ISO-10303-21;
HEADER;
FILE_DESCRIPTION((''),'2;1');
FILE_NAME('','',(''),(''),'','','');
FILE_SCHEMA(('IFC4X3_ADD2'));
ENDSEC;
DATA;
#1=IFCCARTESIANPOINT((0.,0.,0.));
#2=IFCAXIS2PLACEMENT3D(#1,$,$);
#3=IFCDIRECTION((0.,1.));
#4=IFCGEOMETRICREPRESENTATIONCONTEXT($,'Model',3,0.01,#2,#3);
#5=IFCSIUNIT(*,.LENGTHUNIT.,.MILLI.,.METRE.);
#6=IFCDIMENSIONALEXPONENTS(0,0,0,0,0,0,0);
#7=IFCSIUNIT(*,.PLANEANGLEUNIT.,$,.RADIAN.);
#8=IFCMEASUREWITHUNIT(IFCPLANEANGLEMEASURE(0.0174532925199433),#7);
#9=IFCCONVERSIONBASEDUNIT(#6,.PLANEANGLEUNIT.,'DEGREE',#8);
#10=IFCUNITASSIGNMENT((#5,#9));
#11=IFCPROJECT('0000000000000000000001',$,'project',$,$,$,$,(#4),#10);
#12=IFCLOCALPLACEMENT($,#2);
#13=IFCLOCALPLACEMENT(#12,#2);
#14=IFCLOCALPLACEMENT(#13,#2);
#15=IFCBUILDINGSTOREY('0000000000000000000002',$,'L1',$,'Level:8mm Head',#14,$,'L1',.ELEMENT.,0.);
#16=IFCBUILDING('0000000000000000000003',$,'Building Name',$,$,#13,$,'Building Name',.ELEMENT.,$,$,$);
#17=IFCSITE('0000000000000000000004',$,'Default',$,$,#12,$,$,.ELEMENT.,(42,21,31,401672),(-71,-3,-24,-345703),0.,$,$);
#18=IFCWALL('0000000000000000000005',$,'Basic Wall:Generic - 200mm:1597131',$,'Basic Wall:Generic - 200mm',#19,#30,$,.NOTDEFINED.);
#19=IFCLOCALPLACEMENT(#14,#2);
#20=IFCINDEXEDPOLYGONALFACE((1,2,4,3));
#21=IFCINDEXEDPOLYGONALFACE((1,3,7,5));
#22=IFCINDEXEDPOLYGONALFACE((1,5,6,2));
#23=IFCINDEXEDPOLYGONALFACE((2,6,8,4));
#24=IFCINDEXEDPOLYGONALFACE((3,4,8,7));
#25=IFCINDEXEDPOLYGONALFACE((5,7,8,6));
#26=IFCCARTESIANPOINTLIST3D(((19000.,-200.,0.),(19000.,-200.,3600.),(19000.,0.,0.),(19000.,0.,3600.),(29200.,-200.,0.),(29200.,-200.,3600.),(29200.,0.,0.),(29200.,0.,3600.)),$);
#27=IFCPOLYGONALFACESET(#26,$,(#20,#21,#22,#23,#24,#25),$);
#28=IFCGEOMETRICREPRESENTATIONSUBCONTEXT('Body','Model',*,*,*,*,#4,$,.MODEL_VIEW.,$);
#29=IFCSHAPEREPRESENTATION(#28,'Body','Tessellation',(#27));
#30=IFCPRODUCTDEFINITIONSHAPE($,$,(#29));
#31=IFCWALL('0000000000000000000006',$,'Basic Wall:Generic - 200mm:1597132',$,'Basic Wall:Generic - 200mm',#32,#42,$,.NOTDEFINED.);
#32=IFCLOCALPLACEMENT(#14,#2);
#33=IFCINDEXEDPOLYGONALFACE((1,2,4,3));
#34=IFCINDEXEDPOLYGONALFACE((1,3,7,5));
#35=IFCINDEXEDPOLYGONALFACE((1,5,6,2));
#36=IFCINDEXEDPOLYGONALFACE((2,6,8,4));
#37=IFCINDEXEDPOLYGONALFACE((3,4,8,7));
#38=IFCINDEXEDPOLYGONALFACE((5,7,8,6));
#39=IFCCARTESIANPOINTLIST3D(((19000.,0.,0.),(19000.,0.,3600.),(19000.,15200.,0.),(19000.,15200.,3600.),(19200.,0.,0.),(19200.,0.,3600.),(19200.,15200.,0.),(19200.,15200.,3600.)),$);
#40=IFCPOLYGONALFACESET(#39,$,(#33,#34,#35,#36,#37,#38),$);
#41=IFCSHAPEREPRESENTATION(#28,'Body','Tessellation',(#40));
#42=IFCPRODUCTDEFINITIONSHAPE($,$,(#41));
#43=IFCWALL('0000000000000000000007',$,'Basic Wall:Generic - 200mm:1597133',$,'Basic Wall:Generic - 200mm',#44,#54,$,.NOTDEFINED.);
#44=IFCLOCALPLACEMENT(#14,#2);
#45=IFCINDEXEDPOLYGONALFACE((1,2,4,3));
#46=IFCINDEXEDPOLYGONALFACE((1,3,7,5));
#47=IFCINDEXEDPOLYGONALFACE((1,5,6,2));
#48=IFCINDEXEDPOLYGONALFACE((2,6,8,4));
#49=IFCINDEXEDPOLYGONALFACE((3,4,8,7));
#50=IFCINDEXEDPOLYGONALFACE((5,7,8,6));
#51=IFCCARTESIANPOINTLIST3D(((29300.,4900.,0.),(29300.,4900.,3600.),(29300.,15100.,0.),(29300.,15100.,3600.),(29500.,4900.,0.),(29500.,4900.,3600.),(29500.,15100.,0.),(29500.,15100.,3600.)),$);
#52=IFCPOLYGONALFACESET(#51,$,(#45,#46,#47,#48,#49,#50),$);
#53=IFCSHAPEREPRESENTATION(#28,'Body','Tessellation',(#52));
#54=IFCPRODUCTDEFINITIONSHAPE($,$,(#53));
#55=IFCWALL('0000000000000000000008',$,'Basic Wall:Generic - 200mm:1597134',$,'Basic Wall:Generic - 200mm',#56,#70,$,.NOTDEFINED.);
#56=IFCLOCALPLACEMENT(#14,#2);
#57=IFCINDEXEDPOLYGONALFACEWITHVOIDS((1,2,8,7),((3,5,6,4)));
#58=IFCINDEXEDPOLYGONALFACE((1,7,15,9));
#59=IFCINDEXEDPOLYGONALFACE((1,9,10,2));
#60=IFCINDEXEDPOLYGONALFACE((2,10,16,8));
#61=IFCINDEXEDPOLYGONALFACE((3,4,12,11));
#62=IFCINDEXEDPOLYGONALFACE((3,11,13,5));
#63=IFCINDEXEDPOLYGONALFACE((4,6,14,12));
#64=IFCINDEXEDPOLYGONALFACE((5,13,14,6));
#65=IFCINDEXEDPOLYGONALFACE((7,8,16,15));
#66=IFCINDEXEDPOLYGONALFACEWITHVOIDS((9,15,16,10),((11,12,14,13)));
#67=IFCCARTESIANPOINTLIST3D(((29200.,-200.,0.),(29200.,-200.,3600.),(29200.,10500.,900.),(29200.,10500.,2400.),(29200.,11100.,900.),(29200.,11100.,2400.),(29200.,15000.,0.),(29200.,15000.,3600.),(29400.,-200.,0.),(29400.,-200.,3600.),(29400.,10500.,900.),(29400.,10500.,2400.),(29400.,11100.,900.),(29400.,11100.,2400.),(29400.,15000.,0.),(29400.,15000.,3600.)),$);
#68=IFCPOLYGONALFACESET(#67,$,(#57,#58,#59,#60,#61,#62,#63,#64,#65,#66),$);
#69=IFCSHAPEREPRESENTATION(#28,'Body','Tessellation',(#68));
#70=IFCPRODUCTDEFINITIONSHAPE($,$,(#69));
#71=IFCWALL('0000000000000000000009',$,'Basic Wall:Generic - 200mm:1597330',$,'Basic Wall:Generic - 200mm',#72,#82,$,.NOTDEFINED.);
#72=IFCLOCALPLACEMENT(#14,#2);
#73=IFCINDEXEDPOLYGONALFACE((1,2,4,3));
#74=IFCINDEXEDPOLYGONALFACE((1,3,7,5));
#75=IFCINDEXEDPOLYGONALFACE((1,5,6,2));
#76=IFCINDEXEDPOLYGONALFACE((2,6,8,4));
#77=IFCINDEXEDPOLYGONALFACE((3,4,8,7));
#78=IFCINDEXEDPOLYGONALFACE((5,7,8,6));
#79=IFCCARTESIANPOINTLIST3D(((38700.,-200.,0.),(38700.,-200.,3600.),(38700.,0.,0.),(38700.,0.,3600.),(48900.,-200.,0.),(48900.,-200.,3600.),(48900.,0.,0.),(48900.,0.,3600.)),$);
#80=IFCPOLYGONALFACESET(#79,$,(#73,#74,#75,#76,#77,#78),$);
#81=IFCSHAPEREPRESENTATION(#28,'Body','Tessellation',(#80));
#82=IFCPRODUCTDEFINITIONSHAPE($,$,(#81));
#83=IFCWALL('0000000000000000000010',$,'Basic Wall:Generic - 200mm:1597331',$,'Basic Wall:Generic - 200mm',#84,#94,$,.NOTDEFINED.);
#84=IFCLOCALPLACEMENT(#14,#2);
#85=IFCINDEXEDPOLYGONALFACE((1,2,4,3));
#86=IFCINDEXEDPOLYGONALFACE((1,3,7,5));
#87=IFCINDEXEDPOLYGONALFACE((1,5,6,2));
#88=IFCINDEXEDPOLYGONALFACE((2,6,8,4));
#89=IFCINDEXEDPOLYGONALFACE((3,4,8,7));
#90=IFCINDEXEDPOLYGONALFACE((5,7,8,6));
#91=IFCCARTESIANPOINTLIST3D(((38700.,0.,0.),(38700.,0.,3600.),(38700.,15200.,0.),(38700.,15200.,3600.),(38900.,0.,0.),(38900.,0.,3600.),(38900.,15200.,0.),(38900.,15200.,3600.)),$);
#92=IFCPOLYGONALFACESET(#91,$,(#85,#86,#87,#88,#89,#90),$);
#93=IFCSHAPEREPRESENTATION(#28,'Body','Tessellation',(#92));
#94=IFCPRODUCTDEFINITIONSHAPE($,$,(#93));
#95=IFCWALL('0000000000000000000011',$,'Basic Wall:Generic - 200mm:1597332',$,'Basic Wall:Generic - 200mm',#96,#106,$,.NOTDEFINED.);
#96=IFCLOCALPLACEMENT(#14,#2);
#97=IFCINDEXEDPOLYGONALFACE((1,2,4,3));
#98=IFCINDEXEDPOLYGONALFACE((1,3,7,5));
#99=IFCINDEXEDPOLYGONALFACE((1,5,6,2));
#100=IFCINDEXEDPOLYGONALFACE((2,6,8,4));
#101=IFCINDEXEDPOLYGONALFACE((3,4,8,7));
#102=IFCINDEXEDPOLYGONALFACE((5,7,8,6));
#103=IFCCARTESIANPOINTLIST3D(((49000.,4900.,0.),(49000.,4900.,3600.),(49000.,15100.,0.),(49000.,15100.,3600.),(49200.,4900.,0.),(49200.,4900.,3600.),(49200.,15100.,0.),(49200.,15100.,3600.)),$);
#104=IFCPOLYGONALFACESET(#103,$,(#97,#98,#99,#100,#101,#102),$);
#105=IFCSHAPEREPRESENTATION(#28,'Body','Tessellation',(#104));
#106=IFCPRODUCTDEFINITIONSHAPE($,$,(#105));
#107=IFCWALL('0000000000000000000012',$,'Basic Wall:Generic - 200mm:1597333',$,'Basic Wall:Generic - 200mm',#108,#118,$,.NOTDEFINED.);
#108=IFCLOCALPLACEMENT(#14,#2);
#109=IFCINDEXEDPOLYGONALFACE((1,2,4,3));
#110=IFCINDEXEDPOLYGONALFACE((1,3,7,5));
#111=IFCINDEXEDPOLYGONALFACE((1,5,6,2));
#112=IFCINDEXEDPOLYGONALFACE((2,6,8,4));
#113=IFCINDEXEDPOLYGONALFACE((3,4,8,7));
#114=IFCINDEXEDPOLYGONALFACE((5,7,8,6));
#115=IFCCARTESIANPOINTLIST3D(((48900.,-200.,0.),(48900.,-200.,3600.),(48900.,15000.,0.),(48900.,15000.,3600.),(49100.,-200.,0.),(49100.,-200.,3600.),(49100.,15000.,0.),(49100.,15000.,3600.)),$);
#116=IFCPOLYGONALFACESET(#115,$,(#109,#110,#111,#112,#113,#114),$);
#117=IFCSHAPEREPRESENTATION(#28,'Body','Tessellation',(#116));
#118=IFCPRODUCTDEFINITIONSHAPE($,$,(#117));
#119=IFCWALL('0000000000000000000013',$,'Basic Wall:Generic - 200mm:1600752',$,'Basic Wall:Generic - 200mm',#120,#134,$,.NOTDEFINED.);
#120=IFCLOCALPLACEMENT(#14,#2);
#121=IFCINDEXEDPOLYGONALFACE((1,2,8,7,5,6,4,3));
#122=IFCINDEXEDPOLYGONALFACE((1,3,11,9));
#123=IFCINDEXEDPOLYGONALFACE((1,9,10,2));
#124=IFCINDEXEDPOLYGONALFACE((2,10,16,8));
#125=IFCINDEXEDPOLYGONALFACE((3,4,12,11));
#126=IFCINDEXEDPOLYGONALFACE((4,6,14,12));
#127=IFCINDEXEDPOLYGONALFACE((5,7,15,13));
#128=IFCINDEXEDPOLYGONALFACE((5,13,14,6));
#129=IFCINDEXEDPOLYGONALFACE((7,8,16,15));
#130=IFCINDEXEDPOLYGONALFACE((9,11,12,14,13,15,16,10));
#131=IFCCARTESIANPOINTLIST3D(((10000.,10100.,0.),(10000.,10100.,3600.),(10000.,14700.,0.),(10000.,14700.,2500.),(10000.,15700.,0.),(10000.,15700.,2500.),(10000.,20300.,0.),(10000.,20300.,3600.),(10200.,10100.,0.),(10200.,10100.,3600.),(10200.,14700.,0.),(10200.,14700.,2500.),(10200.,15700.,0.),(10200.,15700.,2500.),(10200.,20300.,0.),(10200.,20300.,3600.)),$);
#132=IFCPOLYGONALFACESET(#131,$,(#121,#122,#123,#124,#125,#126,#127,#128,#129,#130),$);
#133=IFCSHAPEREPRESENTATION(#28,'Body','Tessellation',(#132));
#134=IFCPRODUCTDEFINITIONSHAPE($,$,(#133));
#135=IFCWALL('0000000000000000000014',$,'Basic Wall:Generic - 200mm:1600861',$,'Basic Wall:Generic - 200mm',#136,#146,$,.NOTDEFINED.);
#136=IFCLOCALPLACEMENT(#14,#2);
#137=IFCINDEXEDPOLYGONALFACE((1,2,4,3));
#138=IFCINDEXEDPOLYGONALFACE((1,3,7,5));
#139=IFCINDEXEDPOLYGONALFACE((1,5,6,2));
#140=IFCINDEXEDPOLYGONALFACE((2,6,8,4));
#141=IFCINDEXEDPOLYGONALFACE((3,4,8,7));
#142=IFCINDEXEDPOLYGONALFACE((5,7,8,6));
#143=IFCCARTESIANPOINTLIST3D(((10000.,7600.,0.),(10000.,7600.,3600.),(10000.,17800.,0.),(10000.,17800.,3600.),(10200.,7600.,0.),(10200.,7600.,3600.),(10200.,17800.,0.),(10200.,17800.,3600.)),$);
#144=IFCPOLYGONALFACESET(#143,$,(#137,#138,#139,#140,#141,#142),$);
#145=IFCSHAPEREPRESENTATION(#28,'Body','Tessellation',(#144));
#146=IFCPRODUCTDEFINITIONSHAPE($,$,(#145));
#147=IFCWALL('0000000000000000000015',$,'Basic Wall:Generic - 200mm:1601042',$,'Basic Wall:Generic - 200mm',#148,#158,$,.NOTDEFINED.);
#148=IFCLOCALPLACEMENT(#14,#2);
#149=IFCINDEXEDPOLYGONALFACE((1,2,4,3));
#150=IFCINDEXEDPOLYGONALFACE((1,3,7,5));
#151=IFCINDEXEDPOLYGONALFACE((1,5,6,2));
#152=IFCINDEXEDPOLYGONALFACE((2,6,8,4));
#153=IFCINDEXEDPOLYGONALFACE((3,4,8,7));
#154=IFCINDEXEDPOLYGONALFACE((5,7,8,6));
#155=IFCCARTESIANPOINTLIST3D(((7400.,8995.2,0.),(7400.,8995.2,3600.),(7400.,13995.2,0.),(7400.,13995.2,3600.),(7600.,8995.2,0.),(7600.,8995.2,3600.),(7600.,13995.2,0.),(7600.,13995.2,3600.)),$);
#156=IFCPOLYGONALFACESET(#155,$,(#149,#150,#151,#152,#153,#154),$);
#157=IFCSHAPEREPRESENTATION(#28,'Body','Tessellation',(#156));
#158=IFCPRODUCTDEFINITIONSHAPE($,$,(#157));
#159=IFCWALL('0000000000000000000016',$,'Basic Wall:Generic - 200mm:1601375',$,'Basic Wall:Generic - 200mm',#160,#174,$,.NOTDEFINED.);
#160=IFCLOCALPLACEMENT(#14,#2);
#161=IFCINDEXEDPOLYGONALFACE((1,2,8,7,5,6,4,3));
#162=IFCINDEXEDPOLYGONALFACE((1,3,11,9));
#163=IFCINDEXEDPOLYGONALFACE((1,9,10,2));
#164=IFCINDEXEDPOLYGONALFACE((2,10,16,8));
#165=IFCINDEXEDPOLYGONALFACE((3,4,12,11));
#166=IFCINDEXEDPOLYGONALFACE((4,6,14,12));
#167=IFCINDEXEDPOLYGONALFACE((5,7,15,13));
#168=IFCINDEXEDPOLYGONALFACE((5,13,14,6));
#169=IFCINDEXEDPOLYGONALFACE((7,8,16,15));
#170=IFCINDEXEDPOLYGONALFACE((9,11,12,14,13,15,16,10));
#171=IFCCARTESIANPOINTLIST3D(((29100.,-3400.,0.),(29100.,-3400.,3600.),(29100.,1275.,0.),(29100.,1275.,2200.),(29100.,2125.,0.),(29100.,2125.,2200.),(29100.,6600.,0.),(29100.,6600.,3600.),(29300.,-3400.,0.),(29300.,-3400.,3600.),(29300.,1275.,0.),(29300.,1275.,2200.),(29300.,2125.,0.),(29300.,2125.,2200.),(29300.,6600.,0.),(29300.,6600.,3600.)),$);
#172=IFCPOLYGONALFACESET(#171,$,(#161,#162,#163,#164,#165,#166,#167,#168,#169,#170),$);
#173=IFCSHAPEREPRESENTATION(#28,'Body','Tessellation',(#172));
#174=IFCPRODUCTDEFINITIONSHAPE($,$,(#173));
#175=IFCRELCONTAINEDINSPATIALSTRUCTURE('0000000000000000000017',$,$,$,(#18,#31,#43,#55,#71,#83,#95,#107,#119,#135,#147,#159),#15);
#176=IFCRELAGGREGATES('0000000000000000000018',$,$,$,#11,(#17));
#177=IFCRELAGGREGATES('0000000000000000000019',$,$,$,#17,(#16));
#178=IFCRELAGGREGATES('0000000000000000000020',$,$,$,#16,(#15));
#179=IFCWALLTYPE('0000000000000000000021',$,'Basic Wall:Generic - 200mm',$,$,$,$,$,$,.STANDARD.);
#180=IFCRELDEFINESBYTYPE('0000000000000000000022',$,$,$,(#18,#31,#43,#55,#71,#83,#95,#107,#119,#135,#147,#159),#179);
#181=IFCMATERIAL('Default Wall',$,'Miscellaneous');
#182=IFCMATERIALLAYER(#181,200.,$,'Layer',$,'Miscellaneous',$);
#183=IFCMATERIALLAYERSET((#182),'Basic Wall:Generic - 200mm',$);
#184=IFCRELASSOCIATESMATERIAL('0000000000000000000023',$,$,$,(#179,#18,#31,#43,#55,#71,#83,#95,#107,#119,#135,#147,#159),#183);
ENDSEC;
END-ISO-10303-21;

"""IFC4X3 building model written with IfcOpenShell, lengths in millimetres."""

from ifc_helpers import new_model, entity, si_unit, converted_unit, direction, frame, frame_2d, origin, origin_2d_with_axis, place, context, subcontext, project, spatial, rectangle, extrude, material, layer, layer_set, type_object, element, save


model = new_model("IFC4X3")

# Units and contexts
model_context = context("Model", 3, precision=0.01, world=origin(), true_north=direction((0.0, 1.0)))
body_context = subcontext(model_context, "Body", "Model", "MODEL_VIEW")
ifc_project = project(units=[si_unit("LENGTHUNIT", "METRE", prefix="MILLI"), converted_unit("PLANEANGLEUNIT", "DEGREE", entity("IfcPlaneAngleMeasure", 0.0174532925199433), si_unit("PLANEANGLEUNIT", "RADIAN"), dimensions=[0, 0, 0, 0, 0, 0, 0])], contexts=[model_context])

# Site, building, storey
site_placement = place(None, origin())
site = spatial("IfcSite", under=ifc_project, at=site_placement, Name="Default", CompositionType="ELEMENT", RefLatitude=(42, 21, 31, 401672), RefLongitude=(-71, -3, -24, -345703), RefElevation=0.0)
building_placement = place(site_placement, origin())
building = spatial("IfcBuilding", under=site, at=building_placement, Name="Building Name", LongName="Building Name", CompositionType="ELEMENT")
storey_placement = place(building_placement, origin())
storey = spatial("IfcBuildingStorey", under=building, at=storey_placement, Name="L1", ObjectType="Level:8mm Head", LongName="L1", CompositionType="ELEMENT", Elevation=0.0)

# Walls
ifc_material_1 = material(Name="Default Wall", Category="Miscellaneous")
ifc_layer_1 = layer(ifc_material_1, 200.0, Name="Layer", Category="Miscellaneous")
ifc_layer_set_1 = layer_set([ifc_layer_1], Name="Basic Wall:Generic - 200mm")
wall_type_1 = type_object("IfcWallType", Name="Basic Wall:Generic - 200mm", PredefinedType="STANDARD", material=ifc_layer_set_1)
wall_1_placement = place(storey_placement, frame((19000.0, -100.0, 0.0)))
element("IfcWall", 1, at=wall_1_placement, inside=storey, type_object=wall_type_1, material=ifc_layer_set_1, Name="Basic Wall:Generic - 200mm:1597131", ObjectType="Basic Wall:Generic - 200mm", PredefinedType="NOTDEFINED", context=body_context, shape_type="SweptSolid", body=[
    extrude(rectangle(XDim=10200.0, YDim=200.0, at=frame_2d((5100.0, 0.0), x_axis=(-1.0, 0.0))), origin(), (0.0, 0.0, 1.0), 3600.0),
])
wall_2_placement = place(storey_placement, frame((19100.0, 15200.0, 0.0), z_axis=(0.0, 0.0, 1.0), x_axis=(0.0, -1.0, 0.0)))
element("IfcWall", 2, at=wall_2_placement, inside=storey, type_object=wall_type_1, material=ifc_layer_set_1, Name="Basic Wall:Generic - 200mm:1597132", ObjectType="Basic Wall:Generic - 200mm", PredefinedType="NOTDEFINED", context=body_context, shape_type="SweptSolid", body=[
    extrude(rectangle(XDim=15200.0, YDim=200.0, at=frame_2d((7600.0, 0.0), x_axis=(-1.0, 0.0))), origin(), (0.0, 0.0, 1.0), 3600.0),
])
wall_3_placement = place(storey_placement, frame((29400.0, 15100.0, 0.0), z_axis=(0.0, 0.0, 1.0), x_axis=(0.0, -1.0, 0.0)))
element("IfcWall", 3, at=wall_3_placement, inside=storey, type_object=wall_type_1, material=ifc_layer_set_1, Name="Basic Wall:Generic - 200mm:1597133", ObjectType="Basic Wall:Generic - 200mm", PredefinedType="NOTDEFINED", context=body_context, shape_type="SweptSolid", body=[
    extrude(rectangle(XDim=10200.0, YDim=200.0, at=frame_2d((5100.0, 0.0), x_axis=(-1.0, 0.0))), origin(), (0.0, 0.0, 1.0), 3600.0),
])

# Wall, opening
wall_4_placement = place(storey_placement, frame((29300.0, -200.0, 0.0), z_axis=(0.0, 0.0, 1.0), x_axis=(0.0, 1.0, 0.0)))
wall_4 = element("IfcWall", 4, at=wall_4_placement, inside=storey, type_object=wall_type_1, material=ifc_layer_set_1, Name="Basic Wall:Generic - 200mm:1597134", ObjectType="Basic Wall:Generic - 200mm", PredefinedType="NOTDEFINED", context=body_context, shape_type="SweptSolid", body=[
    extrude(rectangle(XDim=15200.0, YDim=200.0, at=frame_2d((7600.0, 0.0), x_axis=(-1.0, 0.0))), origin(), (0.0, 0.0, 1.0), 3600.0),
])
opening_1_placement = place(wall_4_placement, frame((11300.0, 100.0, 900.0)))
element("IfcOpeningElement", 5, at=opening_1_placement, cuts=wall_4, PredefinedType="OPENING", context=body_context, shape_type="SweptSolid", body=[
    extrude(rectangle(XDim=1500.0, YDim=600.0, at=frame_2d((750.0, 300.0), x_axis=(-1.0, 0.0))), frame((0.0, 0.0, 0.0), z_axis=(0.0, -1.0, 0.0), x_axis=(0.0, 0.0, 1.0)), (0.0, 0.0, 1.0), 200.0),
])

# Walls
wall_5_placement = place(storey_placement, frame((38700.0, -100.0, 0.0)))
element("IfcWall", 6, at=wall_5_placement, inside=storey, type_object=wall_type_1, material=ifc_layer_set_1, Name="Basic Wall:Generic - 200mm:1597330", ObjectType="Basic Wall:Generic - 200mm", PredefinedType="NOTDEFINED", context=body_context, shape_type="SweptSolid", body=[
    extrude(rectangle(XDim=10200.0, YDim=200.0, at=frame_2d((5100.0, 0.0), x_axis=(-1.0, 0.0))), origin(), (0.0, 0.0, 1.0), 3600.0),
])
wall_6_placement = place(storey_placement, frame((38800.0, 15200.0, 0.0), z_axis=(0.0, 0.0, 1.0), x_axis=(0.0, -1.0, 0.0)))
element("IfcWall", 7, at=wall_6_placement, inside=storey, type_object=wall_type_1, material=ifc_layer_set_1, Name="Basic Wall:Generic - 200mm:1597331", ObjectType="Basic Wall:Generic - 200mm", PredefinedType="NOTDEFINED", context=body_context, shape_type="SweptSolid", body=[
    extrude(rectangle(XDim=15200.0, YDim=200.0, at=frame_2d((7600.0, 0.0), x_axis=(-1.0, 0.0))), origin(), (0.0, 0.0, 1.0), 3600.0),
])
wall_7_placement = place(storey_placement, frame((49100.0, 15100.0, 0.0), z_axis=(0.0, 0.0, 1.0), x_axis=(0.0, -1.0, 0.0)))
element("IfcWall", 8, at=wall_7_placement, inside=storey, type_object=wall_type_1, material=ifc_layer_set_1, Name="Basic Wall:Generic - 200mm:1597332", ObjectType="Basic Wall:Generic - 200mm", PredefinedType="NOTDEFINED", context=body_context, shape_type="SweptSolid", body=[
    extrude(rectangle(XDim=10200.0, YDim=200.0, at=frame_2d((5100.0, 0.0), x_axis=(-1.0, 0.0))), origin(), (0.0, 0.0, 1.0), 3600.0),
])
wall_8_placement = place(storey_placement, frame((49000.0, -200.0, 0.0), z_axis=(0.0, 0.0, 1.0), x_axis=(0.0, 1.0, 0.0)))
element("IfcWall", 9, at=wall_8_placement, inside=storey, type_object=wall_type_1, material=ifc_layer_set_1, Name="Basic Wall:Generic - 200mm:1597333", ObjectType="Basic Wall:Generic - 200mm", PredefinedType="NOTDEFINED", context=body_context, shape_type="SweptSolid", body=[
    extrude(rectangle(XDim=15200.0, YDim=200.0, at=frame_2d((7600.0, 0.0), x_axis=(-1.0, 0.0))), origin(), (0.0, 0.0, 1.0), 3600.0),
])

# Wall, opening
wall_9_placement = place(storey_placement, frame((10100.0, 20300.0, 0.0), z_axis=(0.0, 0.0, 1.0), x_axis=(0.0, -1.0, 0.0)))
wall_9 = element("IfcWall", 10, at=wall_9_placement, inside=storey, type_object=wall_type_1, material=ifc_layer_set_1, Name="Basic Wall:Generic - 200mm:1600752", ObjectType="Basic Wall:Generic - 200mm", PredefinedType="NOTDEFINED", context=body_context, shape_type="SweptSolid", body=[
    extrude(rectangle(XDim=10200.0, YDim=200.0, at=frame_2d((5100.0, 0.0), x_axis=(1.0, 0.0))), origin(), (0.0, 0.0, 1.0), 3600.0),
])
opening_2_placement = place(wall_9_placement, frame((5600.0, 100.0, 0.0)))
element("IfcOpeningElement", 11, at=opening_2_placement, cuts=wall_9, PredefinedType="OPENING", context=body_context, shape_type="SweptSolid", body=[
    extrude(rectangle(XDim=2500.0, YDim=1000.0, at=origin_2d_with_axis()), frame((-500.0, -200.0, 1250.0), z_axis=(0.0, 1.0, 0.0), x_axis=(0.0, 0.0, -1.0)), (0.0, 0.0, 1.0), 200.0),
])

# Walls
wall_10_placement = place(storey_placement, frame((10100.0, 17800.0, 0.0), z_axis=(0.0, 0.0, 1.0), x_axis=(0.0, -1.0, 0.0)))
element("IfcWall", 12, at=wall_10_placement, inside=storey, type_object=wall_type_1, material=ifc_layer_set_1, Name="Basic Wall:Generic - 200mm:1600861", ObjectType="Basic Wall:Generic - 200mm", PredefinedType="NOTDEFINED", context=body_context, shape_type="SweptSolid", body=[
    extrude(rectangle(XDim=10200.0, YDim=200.0, at=frame_2d((5100.0, 0.0), x_axis=(-1.0, 0.0))), origin(), (0.0, 0.0, 1.0), 3600.0),
])
wall_11_placement = place(storey_placement, frame((7500.0, 13995.2, 0.0), z_axis=(0.0, 0.0, 1.0), x_axis=(0.0, -1.0, 0.0)))
element("IfcWall", 13, at=wall_11_placement, inside=storey, type_object=wall_type_1, material=ifc_layer_set_1, Name="Basic Wall:Generic - 200mm:1601042", ObjectType="Basic Wall:Generic - 200mm", PredefinedType="NOTDEFINED", context=body_context, shape_type="SweptSolid", body=[
    extrude(rectangle(XDim=5000.0, YDim=200.0, at=frame_2d((2500.0, 0.0), x_axis=(-1.0, 0.0))), origin(), (0.0, 0.0, 1.0), 3600.0),
])

# Wall, opening
wall_12_placement = place(storey_placement, frame((29200.0, 6600.0, 0.0), z_axis=(0.0, 0.0, 1.0), x_axis=(0.0, -1.0, 0.0)))
wall_12 = element("IfcWall", 14, at=wall_12_placement, inside=storey, type_object=wall_type_1, material=ifc_layer_set_1, Name="Basic Wall:Generic - 200mm:1601375", ObjectType="Basic Wall:Generic - 200mm", PredefinedType="NOTDEFINED", context=body_context, shape_type="SweptSolid", body=[
    extrude(rectangle(XDim=10000.0, YDim=200.0, at=frame_2d((5000.0, 0.0), x_axis=(1.0, 0.0))), origin(), (0.0, 0.0, 1.0), 3600.0),
])
opening_3_placement = place(wall_12_placement, frame((5325.0, 100.0, 0.0)))
element("IfcOpeningElement", 15, at=opening_3_placement, cuts=wall_12, PredefinedType="OPENING", context=body_context, shape_type="SweptSolid", body=[
    extrude(rectangle(XDim=2200.0, YDim=850.0, at=frame_2d((1100.0, 425.0), x_axis=(1.0, 0.0))), frame((0.0, 0.0, 0.0), z_axis=(0.0, -1.0, 0.0), x_axis=(0.0, 0.0, 1.0)), (0.0, 0.0, 1.0), 200.0),
])

save(model, "model.ifc")
